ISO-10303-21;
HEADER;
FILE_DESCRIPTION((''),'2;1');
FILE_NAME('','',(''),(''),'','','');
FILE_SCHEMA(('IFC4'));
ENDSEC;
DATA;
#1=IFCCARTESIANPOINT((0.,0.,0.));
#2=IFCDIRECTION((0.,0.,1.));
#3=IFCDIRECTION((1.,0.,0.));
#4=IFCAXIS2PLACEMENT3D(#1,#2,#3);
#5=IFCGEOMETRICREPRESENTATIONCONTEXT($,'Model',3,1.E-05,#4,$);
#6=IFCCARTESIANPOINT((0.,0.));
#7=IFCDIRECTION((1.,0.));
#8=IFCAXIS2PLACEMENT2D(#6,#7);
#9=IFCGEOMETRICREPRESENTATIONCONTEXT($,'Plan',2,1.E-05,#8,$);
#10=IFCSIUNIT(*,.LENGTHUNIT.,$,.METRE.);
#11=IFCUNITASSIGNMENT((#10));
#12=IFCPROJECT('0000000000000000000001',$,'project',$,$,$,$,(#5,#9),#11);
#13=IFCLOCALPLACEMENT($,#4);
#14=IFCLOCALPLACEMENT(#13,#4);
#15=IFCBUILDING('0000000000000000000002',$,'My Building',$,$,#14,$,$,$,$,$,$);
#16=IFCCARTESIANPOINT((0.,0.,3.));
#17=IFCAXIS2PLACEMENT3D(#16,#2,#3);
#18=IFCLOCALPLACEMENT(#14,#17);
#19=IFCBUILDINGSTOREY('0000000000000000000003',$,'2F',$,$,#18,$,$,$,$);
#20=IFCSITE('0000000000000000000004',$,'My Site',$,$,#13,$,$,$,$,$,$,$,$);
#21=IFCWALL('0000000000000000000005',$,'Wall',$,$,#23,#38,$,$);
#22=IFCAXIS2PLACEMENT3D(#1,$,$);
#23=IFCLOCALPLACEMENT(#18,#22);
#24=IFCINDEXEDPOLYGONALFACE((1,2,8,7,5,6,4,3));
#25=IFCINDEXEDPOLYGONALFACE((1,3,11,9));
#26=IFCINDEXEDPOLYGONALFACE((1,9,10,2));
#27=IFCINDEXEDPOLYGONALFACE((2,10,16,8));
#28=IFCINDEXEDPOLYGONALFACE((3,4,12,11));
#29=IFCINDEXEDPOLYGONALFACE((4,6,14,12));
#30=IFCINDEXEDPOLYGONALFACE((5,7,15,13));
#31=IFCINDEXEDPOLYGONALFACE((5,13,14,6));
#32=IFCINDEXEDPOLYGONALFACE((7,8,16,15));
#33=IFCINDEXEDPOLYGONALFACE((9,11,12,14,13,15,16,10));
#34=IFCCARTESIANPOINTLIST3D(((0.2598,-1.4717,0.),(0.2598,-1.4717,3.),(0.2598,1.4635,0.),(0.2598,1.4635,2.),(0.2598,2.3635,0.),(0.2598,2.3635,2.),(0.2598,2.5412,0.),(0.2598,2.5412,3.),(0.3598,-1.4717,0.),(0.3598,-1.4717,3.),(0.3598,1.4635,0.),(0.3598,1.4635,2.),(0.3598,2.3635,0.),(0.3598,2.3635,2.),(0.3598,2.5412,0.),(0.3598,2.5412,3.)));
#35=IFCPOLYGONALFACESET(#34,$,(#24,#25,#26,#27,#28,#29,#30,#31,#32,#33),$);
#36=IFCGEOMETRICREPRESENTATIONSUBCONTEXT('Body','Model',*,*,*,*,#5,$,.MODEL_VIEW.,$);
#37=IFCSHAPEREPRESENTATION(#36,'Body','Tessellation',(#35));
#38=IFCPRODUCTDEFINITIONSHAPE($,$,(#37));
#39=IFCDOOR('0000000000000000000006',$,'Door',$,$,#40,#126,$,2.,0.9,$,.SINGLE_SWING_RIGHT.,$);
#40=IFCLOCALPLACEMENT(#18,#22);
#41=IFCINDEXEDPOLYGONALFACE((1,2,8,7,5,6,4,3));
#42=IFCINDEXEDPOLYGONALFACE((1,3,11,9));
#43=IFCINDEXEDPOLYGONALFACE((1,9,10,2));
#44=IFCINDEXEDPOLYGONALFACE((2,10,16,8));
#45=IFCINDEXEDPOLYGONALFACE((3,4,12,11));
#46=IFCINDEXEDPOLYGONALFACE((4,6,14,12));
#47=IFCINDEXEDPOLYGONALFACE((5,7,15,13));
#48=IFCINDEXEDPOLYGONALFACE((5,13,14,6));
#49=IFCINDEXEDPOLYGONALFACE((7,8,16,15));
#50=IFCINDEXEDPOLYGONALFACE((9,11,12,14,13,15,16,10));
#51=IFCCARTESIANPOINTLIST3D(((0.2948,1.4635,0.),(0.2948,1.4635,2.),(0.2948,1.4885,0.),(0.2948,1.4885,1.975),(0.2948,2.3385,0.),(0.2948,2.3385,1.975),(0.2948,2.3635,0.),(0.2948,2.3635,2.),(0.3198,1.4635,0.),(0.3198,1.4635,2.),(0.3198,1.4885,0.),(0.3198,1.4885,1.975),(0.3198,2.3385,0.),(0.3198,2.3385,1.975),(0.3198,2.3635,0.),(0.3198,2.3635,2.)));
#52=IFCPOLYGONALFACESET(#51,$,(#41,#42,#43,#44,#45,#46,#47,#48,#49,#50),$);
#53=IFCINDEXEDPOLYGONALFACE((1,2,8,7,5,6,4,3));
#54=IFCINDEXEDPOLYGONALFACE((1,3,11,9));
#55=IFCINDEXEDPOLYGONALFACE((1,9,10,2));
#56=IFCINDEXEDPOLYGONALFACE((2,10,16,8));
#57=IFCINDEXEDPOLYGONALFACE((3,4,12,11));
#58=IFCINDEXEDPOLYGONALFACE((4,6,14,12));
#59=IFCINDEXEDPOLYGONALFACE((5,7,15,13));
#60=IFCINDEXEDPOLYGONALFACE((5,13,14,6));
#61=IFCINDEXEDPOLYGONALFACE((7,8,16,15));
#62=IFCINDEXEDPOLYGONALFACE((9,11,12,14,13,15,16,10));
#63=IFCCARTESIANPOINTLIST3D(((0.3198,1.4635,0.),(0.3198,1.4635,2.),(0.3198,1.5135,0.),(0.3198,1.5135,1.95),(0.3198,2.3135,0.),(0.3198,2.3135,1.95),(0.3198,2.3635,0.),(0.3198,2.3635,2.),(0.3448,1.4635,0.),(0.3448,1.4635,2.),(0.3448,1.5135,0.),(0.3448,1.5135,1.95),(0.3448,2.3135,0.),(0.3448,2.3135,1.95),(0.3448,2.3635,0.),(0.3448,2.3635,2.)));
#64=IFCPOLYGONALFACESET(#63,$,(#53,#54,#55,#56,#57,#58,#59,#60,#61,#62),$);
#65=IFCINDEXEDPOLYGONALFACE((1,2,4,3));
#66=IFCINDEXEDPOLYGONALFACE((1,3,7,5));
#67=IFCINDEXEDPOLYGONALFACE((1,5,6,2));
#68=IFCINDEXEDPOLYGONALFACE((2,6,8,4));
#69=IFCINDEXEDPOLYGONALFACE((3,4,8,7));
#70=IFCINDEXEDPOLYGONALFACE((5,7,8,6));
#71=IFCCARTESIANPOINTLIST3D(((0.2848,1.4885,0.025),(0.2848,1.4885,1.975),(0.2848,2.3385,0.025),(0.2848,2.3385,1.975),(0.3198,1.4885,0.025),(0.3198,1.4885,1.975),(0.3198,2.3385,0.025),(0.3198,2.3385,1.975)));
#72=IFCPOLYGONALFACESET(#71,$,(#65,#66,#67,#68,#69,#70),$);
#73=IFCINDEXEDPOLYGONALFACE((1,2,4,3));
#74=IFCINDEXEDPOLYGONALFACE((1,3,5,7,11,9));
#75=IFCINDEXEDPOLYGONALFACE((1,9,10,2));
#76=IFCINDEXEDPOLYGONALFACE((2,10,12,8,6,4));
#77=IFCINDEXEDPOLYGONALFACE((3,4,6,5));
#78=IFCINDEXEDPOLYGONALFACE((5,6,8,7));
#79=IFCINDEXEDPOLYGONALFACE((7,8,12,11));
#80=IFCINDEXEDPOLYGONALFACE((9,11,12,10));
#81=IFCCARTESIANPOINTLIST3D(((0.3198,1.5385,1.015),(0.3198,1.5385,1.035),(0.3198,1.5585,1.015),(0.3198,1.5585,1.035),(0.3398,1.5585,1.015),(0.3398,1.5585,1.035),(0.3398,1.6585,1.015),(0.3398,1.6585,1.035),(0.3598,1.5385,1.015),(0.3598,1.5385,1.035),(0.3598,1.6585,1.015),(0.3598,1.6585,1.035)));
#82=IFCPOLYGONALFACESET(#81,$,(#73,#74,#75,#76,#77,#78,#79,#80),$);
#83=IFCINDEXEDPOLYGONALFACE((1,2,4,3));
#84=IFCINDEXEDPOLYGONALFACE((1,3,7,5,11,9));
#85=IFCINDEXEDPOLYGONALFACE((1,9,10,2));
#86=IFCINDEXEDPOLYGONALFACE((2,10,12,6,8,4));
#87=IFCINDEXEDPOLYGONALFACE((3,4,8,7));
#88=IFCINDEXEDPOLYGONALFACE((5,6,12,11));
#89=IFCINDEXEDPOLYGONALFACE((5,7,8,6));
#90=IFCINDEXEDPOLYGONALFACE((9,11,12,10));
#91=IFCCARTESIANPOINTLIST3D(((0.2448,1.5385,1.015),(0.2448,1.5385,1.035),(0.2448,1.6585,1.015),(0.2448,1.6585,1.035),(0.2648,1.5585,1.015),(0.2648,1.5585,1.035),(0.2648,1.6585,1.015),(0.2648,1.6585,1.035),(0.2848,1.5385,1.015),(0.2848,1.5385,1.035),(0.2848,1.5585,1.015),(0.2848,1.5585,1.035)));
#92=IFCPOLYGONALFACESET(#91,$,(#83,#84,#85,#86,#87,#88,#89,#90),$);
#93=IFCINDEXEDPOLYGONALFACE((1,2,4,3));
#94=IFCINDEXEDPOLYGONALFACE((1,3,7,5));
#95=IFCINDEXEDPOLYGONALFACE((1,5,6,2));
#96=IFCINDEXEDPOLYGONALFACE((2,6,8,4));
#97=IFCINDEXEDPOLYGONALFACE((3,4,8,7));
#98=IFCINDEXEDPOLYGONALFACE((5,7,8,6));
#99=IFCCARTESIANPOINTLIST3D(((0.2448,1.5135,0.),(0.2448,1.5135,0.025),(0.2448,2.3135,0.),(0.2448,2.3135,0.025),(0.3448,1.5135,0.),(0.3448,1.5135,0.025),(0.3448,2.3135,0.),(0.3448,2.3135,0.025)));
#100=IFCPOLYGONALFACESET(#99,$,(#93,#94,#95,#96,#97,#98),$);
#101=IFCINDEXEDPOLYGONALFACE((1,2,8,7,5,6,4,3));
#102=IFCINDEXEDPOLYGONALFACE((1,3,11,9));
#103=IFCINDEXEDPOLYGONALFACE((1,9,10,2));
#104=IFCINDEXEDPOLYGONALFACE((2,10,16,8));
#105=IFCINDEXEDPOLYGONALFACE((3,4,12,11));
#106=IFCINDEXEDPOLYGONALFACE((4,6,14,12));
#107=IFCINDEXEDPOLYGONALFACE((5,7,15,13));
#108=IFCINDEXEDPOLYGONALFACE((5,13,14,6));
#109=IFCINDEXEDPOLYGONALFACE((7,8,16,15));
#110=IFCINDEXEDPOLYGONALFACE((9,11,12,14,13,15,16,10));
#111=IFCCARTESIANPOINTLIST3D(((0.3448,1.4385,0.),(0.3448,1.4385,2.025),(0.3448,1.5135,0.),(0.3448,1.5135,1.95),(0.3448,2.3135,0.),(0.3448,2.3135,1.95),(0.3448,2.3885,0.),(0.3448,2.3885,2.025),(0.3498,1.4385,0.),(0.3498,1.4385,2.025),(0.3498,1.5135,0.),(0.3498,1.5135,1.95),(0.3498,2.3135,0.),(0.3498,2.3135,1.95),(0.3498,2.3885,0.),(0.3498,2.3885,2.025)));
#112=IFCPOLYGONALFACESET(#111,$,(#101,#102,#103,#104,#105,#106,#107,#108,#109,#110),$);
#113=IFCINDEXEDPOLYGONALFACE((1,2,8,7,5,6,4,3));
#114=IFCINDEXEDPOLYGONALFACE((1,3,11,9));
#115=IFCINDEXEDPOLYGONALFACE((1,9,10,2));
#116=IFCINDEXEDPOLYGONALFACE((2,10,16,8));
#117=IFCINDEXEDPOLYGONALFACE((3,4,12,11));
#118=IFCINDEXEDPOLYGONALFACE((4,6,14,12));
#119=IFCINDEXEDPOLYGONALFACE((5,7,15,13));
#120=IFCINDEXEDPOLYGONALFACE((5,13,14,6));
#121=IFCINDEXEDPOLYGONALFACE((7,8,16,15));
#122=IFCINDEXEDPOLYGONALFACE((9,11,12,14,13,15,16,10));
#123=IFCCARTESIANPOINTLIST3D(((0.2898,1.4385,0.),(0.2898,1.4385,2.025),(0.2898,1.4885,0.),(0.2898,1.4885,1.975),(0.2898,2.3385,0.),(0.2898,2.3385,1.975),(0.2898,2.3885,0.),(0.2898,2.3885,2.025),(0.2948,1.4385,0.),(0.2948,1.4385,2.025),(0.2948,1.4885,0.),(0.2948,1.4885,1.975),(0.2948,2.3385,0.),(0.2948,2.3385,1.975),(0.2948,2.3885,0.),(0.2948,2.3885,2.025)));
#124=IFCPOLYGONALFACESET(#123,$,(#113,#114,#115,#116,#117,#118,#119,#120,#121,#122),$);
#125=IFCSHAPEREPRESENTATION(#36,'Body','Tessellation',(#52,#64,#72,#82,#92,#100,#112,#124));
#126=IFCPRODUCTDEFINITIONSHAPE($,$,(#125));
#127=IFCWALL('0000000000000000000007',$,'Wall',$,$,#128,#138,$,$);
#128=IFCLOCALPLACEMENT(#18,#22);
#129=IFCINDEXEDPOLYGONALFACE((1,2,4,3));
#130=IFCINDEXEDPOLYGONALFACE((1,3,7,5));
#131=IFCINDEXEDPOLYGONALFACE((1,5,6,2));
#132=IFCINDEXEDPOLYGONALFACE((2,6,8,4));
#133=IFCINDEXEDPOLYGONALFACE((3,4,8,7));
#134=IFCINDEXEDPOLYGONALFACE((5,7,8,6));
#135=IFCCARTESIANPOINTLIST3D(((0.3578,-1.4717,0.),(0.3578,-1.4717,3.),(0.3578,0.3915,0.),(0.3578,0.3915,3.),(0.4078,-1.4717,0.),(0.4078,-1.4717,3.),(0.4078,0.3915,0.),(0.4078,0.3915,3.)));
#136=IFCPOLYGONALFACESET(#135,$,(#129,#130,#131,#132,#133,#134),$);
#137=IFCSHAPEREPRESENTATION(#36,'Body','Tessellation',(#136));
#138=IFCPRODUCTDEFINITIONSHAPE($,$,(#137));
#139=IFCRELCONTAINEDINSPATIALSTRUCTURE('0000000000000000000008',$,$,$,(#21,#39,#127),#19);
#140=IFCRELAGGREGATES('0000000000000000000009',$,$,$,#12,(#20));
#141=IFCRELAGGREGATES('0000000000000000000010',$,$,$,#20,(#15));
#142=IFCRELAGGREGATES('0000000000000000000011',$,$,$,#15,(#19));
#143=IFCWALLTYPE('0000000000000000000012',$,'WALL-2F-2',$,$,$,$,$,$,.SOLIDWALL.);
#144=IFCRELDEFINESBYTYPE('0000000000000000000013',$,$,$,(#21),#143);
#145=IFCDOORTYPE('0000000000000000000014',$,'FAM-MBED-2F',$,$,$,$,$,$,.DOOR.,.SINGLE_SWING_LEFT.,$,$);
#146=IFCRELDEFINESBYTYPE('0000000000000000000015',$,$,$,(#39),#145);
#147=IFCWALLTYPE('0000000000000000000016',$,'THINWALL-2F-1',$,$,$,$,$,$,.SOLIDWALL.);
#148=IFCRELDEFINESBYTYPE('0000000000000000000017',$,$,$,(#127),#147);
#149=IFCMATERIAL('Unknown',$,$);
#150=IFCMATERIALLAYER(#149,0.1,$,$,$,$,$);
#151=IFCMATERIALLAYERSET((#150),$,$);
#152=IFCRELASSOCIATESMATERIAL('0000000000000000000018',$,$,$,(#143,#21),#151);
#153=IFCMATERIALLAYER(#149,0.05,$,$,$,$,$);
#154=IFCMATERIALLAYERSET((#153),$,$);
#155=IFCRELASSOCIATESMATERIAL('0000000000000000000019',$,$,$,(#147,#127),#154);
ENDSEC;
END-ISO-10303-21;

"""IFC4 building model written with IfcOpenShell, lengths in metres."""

from ifc_helpers import new_model, entity, si_unit, frame, origin_with_axes, origin_2d_with_axis, place, context, subcontext, project, spatial, line, indexed_curve, outline, extrude, shape, source, transform, mapped, material, layer, layer_set, layer_usage, type_object, type_shapes, element, fill, save


model = new_model("IFC4")

# Units and contexts
model_context = context("Model", 3, precision=1e-05, world=origin_with_axes())
plan_context = context("Plan", 2, precision=1e-05, world=origin_2d_with_axis())
body_context_1 = subcontext(model_context, "Body", "Model", "MODEL_VIEW")
body_context_2 = subcontext(plan_context, "Body", "Plan", "PLAN_VIEW")
ifc_project = project(units=[si_unit("LENGTHUNIT", "METRE")], contexts=[model_context, plan_context])

# Site, building, storey
site_placement = place(None, origin_with_axes())
site = spatial("IfcSite", under=ifc_project, at=site_placement, Name="My Site")
building_placement = place(site_placement, origin_with_axes())
building = spatial("IfcBuilding", under=site, at=building_placement, Name="My Building")
storey_placement = place(building_placement, frame((0.0, 0.0, 3.0), z_axis=(0.0, 0.0, 1.0), x_axis=(1.0, 0.0, 0.0)))
storey = spatial("IfcBuildingStorey", under=building, at=storey_placement, Name="2F")

# Shared definitions
ifc_material = material(Name="Unknown")

# Wall, opening, door
ifc_layer_1 = layer(ifc_material, 0.1)
ifc_layer_set_1 = layer_set([ifc_layer_1])
ifc_layer_usage_1 = layer_usage(ifc_layer_set_1, "AXIS2", "POSITIVE", 0.0)
wall_type_1 = type_object("IfcWallType", Name="WALL-2F-2", PredefinedType="SOLIDWALL", material=ifc_layer_set_1)
wall_1_placement = place(storey_placement, frame((0.3598, -1.4717, 0.0), z_axis=(0.0, 0.0, 1.0), x_axis=(0.0, 1.0, 0.0)))
wall_1 = element("IfcWall", 1, at=wall_1_placement, inside=storey, type_object=wall_type_1, material=ifc_layer_usage_1, Name="Wall", context=body_context_1, shape_type="SweptSolid", body=[
    extrude(outline(indexed_curve([(0.0, 0.0), (0.0, 0.1), (4.0129, 0.1), (4.0129, 0.0)], segments=[line(1, 2, 3, 4, 1)])), origin_with_axes(), (0.0, 0.0, 1.0), 3.0),
])
shared_shape_1 = source(origin_with_axes(), body_context_1, "Body", "SweptSolid", [
    extrude(outline(indexed_curve([(0.0, 0.0), (0.9, 0.0), (0.9, 2.0), (0.0, 2.0)], segments=[line(1, 2, 3, 4, 1)])), frame((0.0, -0.6, 0.0), z_axis=(0.0, -1.0, 0.0), x_axis=(1.0, 0.0, 0.0)), (0.0, 0.0, -1.0), 1.2),
])
opening_1_placement = place(wall_1_placement, frame((2.9352, 0.015, 0.0), z_axis=(0.0, 0.0, 1.0), x_axis=(1.0, 0.0, 0.0)))
opening_1 = element("IfcOpeningElement", 2, at=opening_1_placement, cuts=wall_1, PredefinedType="OPENING", context=body_context_1, shape_type="MappedRepresentation", body=[
    mapped(shared_shape_1, transform((0.0, 0.0, 0.0), x_axis=(1.0, 0.0, 0.0), y_axis=(0.0, 1.0, 0.0), z_axis=(0.0, 0.0, 1.0), scale=1.0)),
])
door_type_1 = type_object("IfcDoorType", Name="FAM-MBED-2F", OperationType="SINGLE_SWING_LEFT", PredefinedType="DOOR")
shared_shape_2 = source(origin_with_axes(), body_context_1, "Body", "SweptSolid", [
    extrude(outline(indexed_curve([(0.0, 0.0), (0.0, 2.0), (0.9, 2.0), (0.9, 0.0), (0.875, 0.0), (0.875, 1.975), (0.025, 1.975), (0.025, 0.0)], segments=[line(1, 2, 3, 4, 5, 6, 7, 8, 1)])), frame((0.0, 0.025, 0.0), z_axis=(0.0, -1.0, 0.0), x_axis=(1.0, 0.0, 0.0)), (0.0, 0.0, -1.0), 0.025),
    extrude(outline(indexed_curve([(0.0, 0.0), (0.0, 2.0), (0.9, 2.0), (0.9, 0.0), (0.85, 0.0), (0.85, 1.95), (0.05, 1.95), (0.05, 0.0)], segments=[line(1, 2, 3, 4, 5, 6, 7, 8, 1)])), frame((0.0, 0.0, 0.0), z_axis=(0.0, -1.0, 0.0), x_axis=(1.0, 0.0, 0.0)), (0.0, 0.0, -1.0), 0.025),
    extrude(outline(indexed_curve([(0.0, 0.0), (0.85, 0.0), (0.85, 0.035), (0.0, 0.035)], segments=[line(1, 2, 3, 4, 1)])), frame((0.025, 0.025, 0.025), z_axis=(0.0, 0.0, 1.0), x_axis=(1.0, 0.0, 0.0)), (0.0, 0.0, 1.0), 1.95),
    extrude(outline(indexed_curve([(0.0, 0.0), (0.0, -0.04), (0.12, -0.04), (0.12, -0.02), (0.02, -0.02), (0.02, 0.0)], segments=[line(1, 2, 3, 4, 5, 6, 1)])), frame((0.075, 0.025, 1.015), z_axis=(0.0, 0.0, 1.0), x_axis=(1.0, 0.0, 0.0)), (0.0, 0.0, 1.0), 0.02),
    extrude(outline(indexed_curve([(0.0, 0.0), (0.0, 0.04), (0.12, 0.04), (0.12, 0.02), (0.02, 0.02), (0.02, 0.0)], segments=[line(1, 2, 3, 4, 5, 6, 1)])), frame((0.075, 0.06, 1.015), z_axis=(0.0, 0.0, 1.0), x_axis=(1.0, 0.0, 0.0)), (0.0, 0.0, 1.0), 0.02),
    extrude(outline(indexed_curve([(0.0, 0.0), (0.8, 0.0), (0.8, 0.1), (0.0, 0.1)], segments=[line(1, 2, 3, 4, 1)])), frame((0.05, 0.0, 0.0), z_axis=(0.0, 0.0, 1.0), x_axis=(1.0, 0.0, 0.0)), (0.0, 0.0, 1.0), 0.025),
    extrude(outline(indexed_curve([(0.0, 0.0), (0.0, 2.025), (0.95, 2.025), (0.95, 0.0), (0.875, 0.0), (0.875, 1.95), (0.075, 1.95), (0.075, 0.0)], segments=[line(1, 2, 3, 4, 5, 6, 7, 8, 1)])), frame((-0.025, -0.005, 0.0), z_axis=(0.0, -1.0, 0.0), x_axis=(1.0, 0.0, 0.0)), (0.0, 0.0, -1.0), 0.005),
    extrude(outline(indexed_curve([(0.0, 0.0), (0.0, 2.025), (0.95, 2.025), (0.95, 0.0), (0.9, 0.0), (0.9, 1.975), (0.05, 1.975), (0.05, 0.0)], segments=[line(1, 2, 3, 4, 5, 6, 7, 8, 1)])), frame((-0.025, 0.05, 0.0), z_axis=(0.0, -1.0, 0.0), x_axis=(1.0, 0.0, 0.0)), (0.0, 0.0, -1.0), 0.005),
])
shared_shape_3 = source(origin_with_axes(), body_context_2, "Body", "Curve2D", [
    entity("IfcIndexedPolyCurve", entity("IfcCartesianPointList2D", [[0.0, 0.0], [0.0, 0.05], [0.025, 0.05], [0.025, 0.025], [0.05, 0.025], [0.05, 0.0]]), [entity("IfcLineIndex", [1, 2, 3, 4, 5, 6, 1])]),
    entity("IfcIndexedPolyCurve", entity("IfcCartesianPointList2D", [[0.9, 0.0], [0.9, 0.05], [0.875, 0.05], [0.875, 0.025], [0.85, 0.025], [0.85, 0.0]]), [entity("IfcLineIndex", [1, 2, 3, 4, 5, 6, 1])]),
    entity("IfcTrimmedCurve", entity("IfcEllipse", entity("IfcAxis2Placement2D", entity("IfcCartesianPoint", [0.84, 0.05]), entity("IfcDirection", [1.0, 0.0])), 0.815, 0.85), [entity("IfcCartesianPoint", [0.84, 0.9])], [entity("IfcCartesianPoint", [0.025, 0.05])], True, "CARTESIAN"),
    entity("IfcIndexedPolyCurve", entity("IfcCartesianPointList2D", [[0.875, 0.05], [0.84, 0.05], [0.84, 0.9], [0.875, 0.9]]), [entity("IfcLineIndex", [1, 2, 3, 4, 1])]),
])
type_shapes(door_type_1, [shared_shape_2, shared_shape_3])
door_1_placement = place(opening_1_placement, frame((0.0, 0.0, 0.0), z_axis=(0.0, 0.0, 1.0), x_axis=(1.0, 0.0, 0.0)))
door_1 = element("IfcDoor", 3, at=door_1_placement, inside=storey, type_object=door_type_1, Name="Door", OperationType="SINGLE_SWING_RIGHT", OverallHeight=2.0, OverallWidth=0.9, shapes=[
    shape(body_context_1, "Body", "MappedRepresentation", [mapped(shared_shape_2, transform((0.0, 0.0, 0.0), x_axis=(1.0, 0.0, 0.0), y_axis=(0.0, 1.0, 0.0), z_axis=(0.0, 0.0, 1.0), scale=1.0))]),
    shape(body_context_2, "Body", "MappedRepresentation", [mapped(shared_shape_3, transform((0.0, 0.0, 0.0), x_axis=(1.0, 0.0, 0.0), y_axis=(0.0, 1.0, 0.0), z_axis=(0.0, 0.0, 1.0), scale=1.0))]),
])
fill(opening_1, door_1)

# Wall
ifc_layer_2 = layer(ifc_material, 0.05)
ifc_layer_set_2 = layer_set([ifc_layer_2])
ifc_layer_usage_2 = layer_usage(ifc_layer_set_2, "AXIS2", "POSITIVE", 0.0)
wall_type_2 = type_object("IfcWallType", Name="THINWALL-2F-1", PredefinedType="SOLIDWALL", material=ifc_layer_set_2)
wall_2_placement = place(storey_placement, frame((0.4078, -1.4717, 0.0), z_axis=(0.0, 0.0, 1.0), x_axis=(0.0, 1.0, 0.0)))
element("IfcWall", 4, at=wall_2_placement, inside=storey, type_object=wall_type_2, material=ifc_layer_usage_2, Name="Wall", context=body_context_1, shape_type="SweptSolid", body=[
    extrude(outline(indexed_curve([(0.0, 0.0), (0.0, 0.05), (1.8632, 0.05), (1.8632, 0.0)], segments=[line(1, 2, 3, 4, 1)])), origin_with_axes(), (0.0, 0.0, 1.0), 3.0),
])

save(model, "model.ifc")
